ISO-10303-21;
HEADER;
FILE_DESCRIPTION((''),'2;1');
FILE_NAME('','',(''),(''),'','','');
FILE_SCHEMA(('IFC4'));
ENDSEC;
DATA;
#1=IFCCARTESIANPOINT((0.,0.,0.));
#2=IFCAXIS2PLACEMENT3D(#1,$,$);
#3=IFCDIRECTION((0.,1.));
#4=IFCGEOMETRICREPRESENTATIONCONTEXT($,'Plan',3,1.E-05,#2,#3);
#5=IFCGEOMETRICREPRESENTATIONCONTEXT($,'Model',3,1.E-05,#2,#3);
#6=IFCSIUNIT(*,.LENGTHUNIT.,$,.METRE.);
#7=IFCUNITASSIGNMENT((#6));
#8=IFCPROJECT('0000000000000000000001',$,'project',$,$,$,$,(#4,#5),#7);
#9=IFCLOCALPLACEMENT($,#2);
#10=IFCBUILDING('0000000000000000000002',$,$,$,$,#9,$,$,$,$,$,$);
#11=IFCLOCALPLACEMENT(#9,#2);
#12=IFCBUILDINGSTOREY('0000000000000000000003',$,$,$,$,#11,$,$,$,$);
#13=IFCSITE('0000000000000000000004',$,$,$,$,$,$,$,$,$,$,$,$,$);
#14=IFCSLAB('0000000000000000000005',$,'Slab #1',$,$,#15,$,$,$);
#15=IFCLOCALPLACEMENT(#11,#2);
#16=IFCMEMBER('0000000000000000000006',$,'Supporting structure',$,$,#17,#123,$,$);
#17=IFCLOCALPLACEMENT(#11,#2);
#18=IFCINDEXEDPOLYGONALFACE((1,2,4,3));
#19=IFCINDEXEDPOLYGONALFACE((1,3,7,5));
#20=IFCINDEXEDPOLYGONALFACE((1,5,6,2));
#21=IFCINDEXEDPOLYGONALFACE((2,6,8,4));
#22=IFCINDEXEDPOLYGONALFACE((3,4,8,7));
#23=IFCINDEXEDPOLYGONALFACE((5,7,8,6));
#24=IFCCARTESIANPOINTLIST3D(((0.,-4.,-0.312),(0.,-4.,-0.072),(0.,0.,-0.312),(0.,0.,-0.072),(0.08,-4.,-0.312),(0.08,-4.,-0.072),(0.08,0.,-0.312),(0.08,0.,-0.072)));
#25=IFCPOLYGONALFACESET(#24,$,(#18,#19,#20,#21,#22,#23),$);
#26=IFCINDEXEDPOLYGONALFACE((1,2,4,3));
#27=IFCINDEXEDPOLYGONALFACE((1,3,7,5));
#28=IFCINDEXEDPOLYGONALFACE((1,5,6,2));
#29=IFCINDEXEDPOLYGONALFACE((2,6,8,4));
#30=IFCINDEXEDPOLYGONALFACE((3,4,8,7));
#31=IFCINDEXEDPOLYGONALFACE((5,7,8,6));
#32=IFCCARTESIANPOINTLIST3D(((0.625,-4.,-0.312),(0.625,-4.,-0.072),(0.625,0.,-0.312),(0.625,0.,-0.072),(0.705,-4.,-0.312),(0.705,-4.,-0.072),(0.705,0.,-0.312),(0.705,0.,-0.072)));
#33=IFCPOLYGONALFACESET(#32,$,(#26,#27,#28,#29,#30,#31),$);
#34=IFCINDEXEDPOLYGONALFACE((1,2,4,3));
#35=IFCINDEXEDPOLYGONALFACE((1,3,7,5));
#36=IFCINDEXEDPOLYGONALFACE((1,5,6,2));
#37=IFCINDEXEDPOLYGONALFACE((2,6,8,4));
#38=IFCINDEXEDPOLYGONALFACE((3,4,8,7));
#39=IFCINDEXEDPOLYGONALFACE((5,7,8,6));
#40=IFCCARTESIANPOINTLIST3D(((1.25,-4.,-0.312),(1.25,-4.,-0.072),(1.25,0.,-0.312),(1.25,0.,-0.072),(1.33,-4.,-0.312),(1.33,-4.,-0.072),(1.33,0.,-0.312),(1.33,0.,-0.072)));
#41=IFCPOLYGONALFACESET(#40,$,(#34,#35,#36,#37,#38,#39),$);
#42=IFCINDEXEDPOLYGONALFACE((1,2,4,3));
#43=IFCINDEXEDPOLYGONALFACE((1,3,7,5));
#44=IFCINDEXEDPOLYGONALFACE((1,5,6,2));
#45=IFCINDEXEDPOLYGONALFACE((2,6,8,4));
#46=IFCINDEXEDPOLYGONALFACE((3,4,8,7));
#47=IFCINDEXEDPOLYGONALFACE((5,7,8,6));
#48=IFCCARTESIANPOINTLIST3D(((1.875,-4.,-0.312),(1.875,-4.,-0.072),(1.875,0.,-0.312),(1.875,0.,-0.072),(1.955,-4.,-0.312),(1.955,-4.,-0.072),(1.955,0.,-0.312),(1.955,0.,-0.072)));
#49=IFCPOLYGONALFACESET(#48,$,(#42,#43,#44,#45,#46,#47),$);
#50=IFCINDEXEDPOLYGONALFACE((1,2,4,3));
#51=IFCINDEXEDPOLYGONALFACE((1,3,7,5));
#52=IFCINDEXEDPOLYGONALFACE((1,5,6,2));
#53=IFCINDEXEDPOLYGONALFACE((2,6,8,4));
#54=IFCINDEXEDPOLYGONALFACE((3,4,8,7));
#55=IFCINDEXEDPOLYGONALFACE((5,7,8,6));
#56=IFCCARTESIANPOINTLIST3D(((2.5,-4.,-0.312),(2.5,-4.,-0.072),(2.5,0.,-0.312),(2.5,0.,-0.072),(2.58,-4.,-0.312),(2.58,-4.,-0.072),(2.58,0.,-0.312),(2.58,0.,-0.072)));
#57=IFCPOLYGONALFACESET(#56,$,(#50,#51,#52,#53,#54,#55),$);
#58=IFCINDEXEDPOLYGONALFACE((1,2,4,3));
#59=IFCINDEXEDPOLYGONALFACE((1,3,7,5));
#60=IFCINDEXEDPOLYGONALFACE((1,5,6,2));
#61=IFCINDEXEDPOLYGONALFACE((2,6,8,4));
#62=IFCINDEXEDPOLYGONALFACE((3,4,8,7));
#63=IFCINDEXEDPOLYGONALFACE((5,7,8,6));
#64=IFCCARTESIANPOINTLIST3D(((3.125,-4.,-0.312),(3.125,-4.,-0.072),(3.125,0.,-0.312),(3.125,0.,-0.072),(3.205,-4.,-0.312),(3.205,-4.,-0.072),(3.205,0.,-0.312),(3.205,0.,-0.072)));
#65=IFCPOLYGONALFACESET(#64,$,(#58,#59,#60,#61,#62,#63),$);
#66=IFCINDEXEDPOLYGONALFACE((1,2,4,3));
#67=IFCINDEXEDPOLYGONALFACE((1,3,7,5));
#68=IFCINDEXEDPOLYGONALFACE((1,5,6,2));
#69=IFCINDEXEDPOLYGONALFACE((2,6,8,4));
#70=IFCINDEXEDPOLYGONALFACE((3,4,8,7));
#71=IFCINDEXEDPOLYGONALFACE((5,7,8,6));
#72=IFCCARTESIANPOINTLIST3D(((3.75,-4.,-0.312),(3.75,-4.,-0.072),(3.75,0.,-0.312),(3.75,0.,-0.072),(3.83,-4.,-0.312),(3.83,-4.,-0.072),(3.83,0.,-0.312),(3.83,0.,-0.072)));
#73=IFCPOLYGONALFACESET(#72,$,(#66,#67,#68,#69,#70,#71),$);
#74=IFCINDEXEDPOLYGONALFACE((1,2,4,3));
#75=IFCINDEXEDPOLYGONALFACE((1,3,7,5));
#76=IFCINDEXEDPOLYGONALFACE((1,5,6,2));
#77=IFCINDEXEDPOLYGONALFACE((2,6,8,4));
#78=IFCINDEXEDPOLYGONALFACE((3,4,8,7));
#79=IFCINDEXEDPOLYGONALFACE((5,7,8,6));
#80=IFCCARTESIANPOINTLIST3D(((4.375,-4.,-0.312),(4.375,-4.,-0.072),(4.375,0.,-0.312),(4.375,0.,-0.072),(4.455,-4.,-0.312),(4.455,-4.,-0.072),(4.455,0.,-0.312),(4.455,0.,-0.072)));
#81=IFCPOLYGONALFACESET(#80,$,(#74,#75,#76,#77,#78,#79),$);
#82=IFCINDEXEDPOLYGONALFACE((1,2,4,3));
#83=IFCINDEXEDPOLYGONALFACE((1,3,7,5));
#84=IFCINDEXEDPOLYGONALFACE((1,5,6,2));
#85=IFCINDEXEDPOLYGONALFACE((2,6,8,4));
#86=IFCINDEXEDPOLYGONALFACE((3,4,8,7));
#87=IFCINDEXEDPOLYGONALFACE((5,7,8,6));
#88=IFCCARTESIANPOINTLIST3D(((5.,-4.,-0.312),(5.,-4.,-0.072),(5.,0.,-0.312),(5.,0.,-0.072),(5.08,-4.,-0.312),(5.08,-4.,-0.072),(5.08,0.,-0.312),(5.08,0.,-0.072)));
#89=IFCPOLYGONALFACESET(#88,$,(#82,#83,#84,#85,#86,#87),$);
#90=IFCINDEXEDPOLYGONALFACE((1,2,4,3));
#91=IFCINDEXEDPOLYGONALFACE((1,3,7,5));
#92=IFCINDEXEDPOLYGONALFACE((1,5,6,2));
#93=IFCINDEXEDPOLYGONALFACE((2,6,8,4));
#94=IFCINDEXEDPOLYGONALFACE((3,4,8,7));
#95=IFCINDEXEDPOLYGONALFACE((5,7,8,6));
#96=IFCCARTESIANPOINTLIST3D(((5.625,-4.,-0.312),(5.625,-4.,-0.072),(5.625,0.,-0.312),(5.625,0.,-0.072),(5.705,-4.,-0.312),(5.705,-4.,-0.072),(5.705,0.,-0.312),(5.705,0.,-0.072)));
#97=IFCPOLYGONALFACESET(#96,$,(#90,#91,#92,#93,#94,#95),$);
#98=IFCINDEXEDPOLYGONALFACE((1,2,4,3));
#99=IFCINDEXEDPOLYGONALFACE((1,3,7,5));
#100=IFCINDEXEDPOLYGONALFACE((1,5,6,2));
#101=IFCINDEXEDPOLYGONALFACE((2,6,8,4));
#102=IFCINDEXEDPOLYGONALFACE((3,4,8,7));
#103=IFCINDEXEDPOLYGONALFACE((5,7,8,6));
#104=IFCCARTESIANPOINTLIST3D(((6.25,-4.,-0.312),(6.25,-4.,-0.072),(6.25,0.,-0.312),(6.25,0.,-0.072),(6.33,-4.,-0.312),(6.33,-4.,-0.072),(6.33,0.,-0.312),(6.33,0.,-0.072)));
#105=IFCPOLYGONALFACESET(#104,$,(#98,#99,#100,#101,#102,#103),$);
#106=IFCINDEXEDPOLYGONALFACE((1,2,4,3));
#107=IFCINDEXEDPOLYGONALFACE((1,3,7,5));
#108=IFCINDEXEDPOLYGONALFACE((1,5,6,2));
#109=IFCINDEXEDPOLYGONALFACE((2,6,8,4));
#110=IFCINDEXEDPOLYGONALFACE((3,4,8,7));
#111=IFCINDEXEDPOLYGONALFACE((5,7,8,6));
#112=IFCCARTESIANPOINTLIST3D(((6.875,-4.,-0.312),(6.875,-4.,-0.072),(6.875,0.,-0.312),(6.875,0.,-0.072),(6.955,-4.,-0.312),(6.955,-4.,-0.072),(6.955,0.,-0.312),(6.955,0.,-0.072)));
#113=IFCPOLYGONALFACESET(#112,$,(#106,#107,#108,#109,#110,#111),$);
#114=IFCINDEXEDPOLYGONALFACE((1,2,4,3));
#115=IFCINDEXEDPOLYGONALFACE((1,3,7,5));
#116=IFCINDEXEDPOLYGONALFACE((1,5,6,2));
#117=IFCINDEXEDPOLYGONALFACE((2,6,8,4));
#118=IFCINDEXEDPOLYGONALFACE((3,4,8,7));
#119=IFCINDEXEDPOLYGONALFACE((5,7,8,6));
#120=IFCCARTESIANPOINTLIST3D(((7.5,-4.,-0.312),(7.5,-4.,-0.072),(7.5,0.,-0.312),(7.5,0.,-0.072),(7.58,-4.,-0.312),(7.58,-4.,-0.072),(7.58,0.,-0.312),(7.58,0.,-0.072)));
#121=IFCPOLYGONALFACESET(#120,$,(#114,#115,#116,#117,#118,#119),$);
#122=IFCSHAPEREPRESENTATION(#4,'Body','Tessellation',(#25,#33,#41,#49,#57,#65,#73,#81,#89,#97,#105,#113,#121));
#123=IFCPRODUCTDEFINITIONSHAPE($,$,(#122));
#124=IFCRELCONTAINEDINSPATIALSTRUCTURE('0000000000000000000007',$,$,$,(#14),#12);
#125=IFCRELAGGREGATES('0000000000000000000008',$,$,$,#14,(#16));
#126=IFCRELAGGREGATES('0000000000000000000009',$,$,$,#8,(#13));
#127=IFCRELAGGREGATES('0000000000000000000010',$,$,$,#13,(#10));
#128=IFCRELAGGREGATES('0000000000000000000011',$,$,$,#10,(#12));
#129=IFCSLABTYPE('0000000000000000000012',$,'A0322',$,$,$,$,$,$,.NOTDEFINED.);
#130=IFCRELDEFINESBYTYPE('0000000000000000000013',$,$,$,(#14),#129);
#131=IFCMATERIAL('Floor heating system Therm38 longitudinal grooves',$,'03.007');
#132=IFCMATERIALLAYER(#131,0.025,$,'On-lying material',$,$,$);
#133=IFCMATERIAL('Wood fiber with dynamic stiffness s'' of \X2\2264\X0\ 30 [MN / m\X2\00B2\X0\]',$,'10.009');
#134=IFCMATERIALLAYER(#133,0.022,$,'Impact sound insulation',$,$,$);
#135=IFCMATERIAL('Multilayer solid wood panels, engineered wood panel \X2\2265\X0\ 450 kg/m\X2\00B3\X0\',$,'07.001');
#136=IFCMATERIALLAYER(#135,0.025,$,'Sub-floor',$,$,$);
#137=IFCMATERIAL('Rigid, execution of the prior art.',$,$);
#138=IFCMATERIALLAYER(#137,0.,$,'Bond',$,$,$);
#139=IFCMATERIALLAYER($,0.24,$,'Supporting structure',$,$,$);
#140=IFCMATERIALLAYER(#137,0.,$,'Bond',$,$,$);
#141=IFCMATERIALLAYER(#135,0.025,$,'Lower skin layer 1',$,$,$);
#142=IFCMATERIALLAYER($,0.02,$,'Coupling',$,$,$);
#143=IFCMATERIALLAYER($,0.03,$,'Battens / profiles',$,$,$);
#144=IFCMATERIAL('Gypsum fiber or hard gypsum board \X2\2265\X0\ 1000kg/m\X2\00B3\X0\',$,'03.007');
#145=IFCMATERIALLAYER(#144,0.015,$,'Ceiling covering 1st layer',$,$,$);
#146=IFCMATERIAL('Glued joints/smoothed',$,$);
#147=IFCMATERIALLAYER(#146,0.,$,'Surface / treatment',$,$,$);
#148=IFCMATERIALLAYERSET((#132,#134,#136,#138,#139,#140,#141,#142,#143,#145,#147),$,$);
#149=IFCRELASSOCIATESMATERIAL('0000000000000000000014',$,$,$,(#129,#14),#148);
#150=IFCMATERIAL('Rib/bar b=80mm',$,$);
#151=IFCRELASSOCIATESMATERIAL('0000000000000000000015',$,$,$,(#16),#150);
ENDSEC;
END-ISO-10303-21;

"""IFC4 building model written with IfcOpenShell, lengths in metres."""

from ifc_helpers import new_model, si_unit, direction, frame, frame_2d, origin, place, context, project, spatial, rectangle, extrude, material, layer, layer_set, type_object, element, aggregate, save


model = new_model("IFC4")

# Units and contexts
plan_context = context("Plan", 3, precision=1e-05, world=origin(), true_north=direction((0.0, 1.0)))
model_context = context("Model", 3, precision=1e-05, world=origin(), true_north=direction((0.0, 1.0)))
ifc_project = project(units=[si_unit("LENGTHUNIT", "METRE")], contexts=[plan_context, model_context])

# Site, building, storey
site = spatial("IfcSite", under=ifc_project)
building_placement = place(None, origin())
building = spatial("IfcBuilding", under=site, at=building_placement)
storey_placement = place(building_placement, origin())
storey = spatial("IfcBuildingStorey", under=building, at=storey_placement)

# Slab, member
ifc_material_1 = material(Name="Floor heating system Therm38 longitudinal grooves", Category="03.007")
ifc_layer_1 = layer(ifc_material_1, 0.025, Name="On-lying material")
ifc_material_2 = material(Name="Wood fiber with dynamic stiffness s' of ≤ 30 [MN / m²]", Category="10.009")
ifc_layer_2 = layer(ifc_material_2, 0.022, Name="Impact sound insulation")
ifc_material_3 = material(Name="Multilayer solid wood panels, engineered wood panel ≥ 450 kg/m³", Category="07.001")
ifc_layer_3 = layer(ifc_material_3, 0.025, Name="Sub-floor")
ifc_material_4 = material(Name="Rigid, execution of the prior art.")
ifc_layer_4 = layer(ifc_material_4, 0.0, Name="Bond")
ifc_layer_5 = layer(None, 0.24, Name="Supporting structure")
ifc_layer_6 = layer(ifc_material_4, 0.0, Name="Bond")
ifc_layer_7 = layer(ifc_material_3, 0.025, Name="Lower skin layer 1")
ifc_layer_8 = layer(None, 0.02, Name="Coupling")
ifc_layer_9 = layer(None, 0.03, Name="Battens / profiles")
ifc_material_5 = material(Name="Gypsum fiber or hard gypsum board ≥ 1000kg/m³", Category="03.007")
ifc_layer_10 = layer(ifc_material_5, 0.015, Name="Ceiling covering 1st layer")
ifc_material_6 = material(Name="Glued joints/smoothed")
ifc_layer_11 = layer(ifc_material_6, 0.0, Name="Surface / treatment")
ifc_layer_set = layer_set([ifc_layer_1, ifc_layer_2, ifc_layer_3, ifc_layer_4, ifc_layer_5, ifc_layer_6, ifc_layer_7, ifc_layer_8, ifc_layer_9, ifc_layer_10, ifc_layer_11])
slab_type = type_object("IfcSlabType", Name="A0322", PredefinedType="NOTDEFINED", material=ifc_layer_set)
slab_placement = place(None, frame((0.0, 0.0, 0.0), z_axis=(0.0, 0.0, -1.0), x_axis=(1.0, 0.0, 0.0)))
slab = element("IfcSlab", 1, at=slab_placement, inside=storey, type_object=slab_type, material=ifc_layer_set, Name="Slab #1")
ifc_material_7 = material(Name="Rib/bar b=80mm")
member_1_placement = place(slab_placement, origin())
member_1 = element("IfcMember", 2, at=member_1_placement, material=ifc_material_7, Name="Supporting structure", context=plan_context, shape_type="SweptSolid", body=[
    extrude(rectangle(XDim=0.08, YDim=0.24, at=frame_2d((0.04, 0.12), x_axis=(1.0, 0.0))), frame((0.0, 4.0, 0.072), z_axis=(0.0, -1.0, 0.0), x_axis=(1.0, 0.0, 0.0)), (0.0, 0.0, 1.0), 4.0),
    extrude(rectangle(XDim=0.08, YDim=0.24, at=frame_2d((0.04, 0.12), x_axis=(1.0, 0.0))), frame((0.625, 4.0, 0.072), z_axis=(0.0, -1.0, 0.0), x_axis=(1.0, 0.0, 0.0)), (0.0, 0.0, 1.0), 4.0),
    extrude(rectangle(XDim=0.08, YDim=0.24, at=frame_2d((0.04, 0.12), x_axis=(1.0, 0.0))), frame((1.25, 4.0, 0.072), z_axis=(0.0, -1.0, 0.0), x_axis=(1.0, 0.0, 0.0)), (0.0, 0.0, 1.0), 4.0),
    extrude(rectangle(XDim=0.08, YDim=0.24, at=frame_2d((0.04, 0.12), x_axis=(1.0, 0.0))), frame((1.875, 4.0, 0.072), z_axis=(0.0, -1.0, 0.0), x_axis=(1.0, 0.0, 0.0)), (0.0, 0.0, 1.0), 4.0),
    extrude(rectangle(XDim=0.08, YDim=0.24, at=frame_2d((0.04, 0.12), x_axis=(1.0, 0.0))), frame((2.5, 4.0, 0.072), z_axis=(0.0, -1.0, 0.0), x_axis=(1.0, 0.0, 0.0)), (0.0, 0.0, 1.0), 4.0),
    extrude(rectangle(XDim=0.08, YDim=0.24, at=frame_2d((0.04, 0.12), x_axis=(1.0, 0.0))), frame((3.125, 4.0, 0.072), z_axis=(0.0, -1.0, 0.0), x_axis=(1.0, 0.0, 0.0)), (0.0, 0.0, 1.0), 4.0),
    extrude(rectangle(XDim=0.08, YDim=0.24, at=frame_2d((0.04, 0.12), x_axis=(1.0, 0.0))), frame((3.75, 4.0, 0.072), z_axis=(0.0, -1.0, 0.0), x_axis=(1.0, 0.0, 0.0)), (0.0, 0.0, 1.0), 4.0),
    extrude(rectangle(XDim=0.08, YDim=0.24, at=frame_2d((0.04, 0.12), x_axis=(1.0, 0.0))), frame((4.375, 4.0, 0.072), z_axis=(0.0, -1.0, 0.0), x_axis=(1.0, 0.0, 0.0)), (0.0, 0.0, 1.0), 4.0),
    extrude(rectangle(XDim=0.08, YDim=0.24, at=frame_2d((0.04, 0.12), x_axis=(1.0, 0.0))), frame((5.0, 4.0, 0.072), z_axis=(0.0, -1.0, 0.0), x_axis=(1.0, 0.0, 0.0)), (0.0, 0.0, 1.0), 4.0),
    extrude(rectangle(XDim=0.08, YDim=0.24, at=frame_2d((0.04, 0.12), x_axis=(1.0, 0.0))), frame((5.625, 4.0, 0.072), z_axis=(0.0, -1.0, 0.0), x_axis=(1.0, 0.0, 0.0)), (0.0, 0.0, 1.0), 4.0),
    extrude(rectangle(XDim=0.08, YDim=0.24, at=frame_2d((0.04, 0.12), x_axis=(1.0, 0.0))), frame((6.25, 4.0, 0.072), z_axis=(0.0, -1.0, 0.0), x_axis=(1.0, 0.0, 0.0)), (0.0, 0.0, 1.0), 4.0),
    extrude(rectangle(XDim=0.08, YDim=0.24, at=frame_2d((0.04, 0.12), x_axis=(1.0, 0.0))), frame((6.875, 4.0, 0.072), z_axis=(0.0, -1.0, 0.0), x_axis=(1.0, 0.0, 0.0)), (0.0, 0.0, 1.0), 4.0),
    extrude(rectangle(XDim=0.08, YDim=0.24, at=frame_2d((0.04, 0.12), x_axis=(1.0, 0.0))), frame((7.5, 4.0, 0.072), z_axis=(0.0, -1.0, 0.0), x_axis=(1.0, 0.0, 0.0)), (0.0, 0.0, 1.0), 4.0),
])
aggregate(slab, [member_1])

save(model, "model.ifc")
